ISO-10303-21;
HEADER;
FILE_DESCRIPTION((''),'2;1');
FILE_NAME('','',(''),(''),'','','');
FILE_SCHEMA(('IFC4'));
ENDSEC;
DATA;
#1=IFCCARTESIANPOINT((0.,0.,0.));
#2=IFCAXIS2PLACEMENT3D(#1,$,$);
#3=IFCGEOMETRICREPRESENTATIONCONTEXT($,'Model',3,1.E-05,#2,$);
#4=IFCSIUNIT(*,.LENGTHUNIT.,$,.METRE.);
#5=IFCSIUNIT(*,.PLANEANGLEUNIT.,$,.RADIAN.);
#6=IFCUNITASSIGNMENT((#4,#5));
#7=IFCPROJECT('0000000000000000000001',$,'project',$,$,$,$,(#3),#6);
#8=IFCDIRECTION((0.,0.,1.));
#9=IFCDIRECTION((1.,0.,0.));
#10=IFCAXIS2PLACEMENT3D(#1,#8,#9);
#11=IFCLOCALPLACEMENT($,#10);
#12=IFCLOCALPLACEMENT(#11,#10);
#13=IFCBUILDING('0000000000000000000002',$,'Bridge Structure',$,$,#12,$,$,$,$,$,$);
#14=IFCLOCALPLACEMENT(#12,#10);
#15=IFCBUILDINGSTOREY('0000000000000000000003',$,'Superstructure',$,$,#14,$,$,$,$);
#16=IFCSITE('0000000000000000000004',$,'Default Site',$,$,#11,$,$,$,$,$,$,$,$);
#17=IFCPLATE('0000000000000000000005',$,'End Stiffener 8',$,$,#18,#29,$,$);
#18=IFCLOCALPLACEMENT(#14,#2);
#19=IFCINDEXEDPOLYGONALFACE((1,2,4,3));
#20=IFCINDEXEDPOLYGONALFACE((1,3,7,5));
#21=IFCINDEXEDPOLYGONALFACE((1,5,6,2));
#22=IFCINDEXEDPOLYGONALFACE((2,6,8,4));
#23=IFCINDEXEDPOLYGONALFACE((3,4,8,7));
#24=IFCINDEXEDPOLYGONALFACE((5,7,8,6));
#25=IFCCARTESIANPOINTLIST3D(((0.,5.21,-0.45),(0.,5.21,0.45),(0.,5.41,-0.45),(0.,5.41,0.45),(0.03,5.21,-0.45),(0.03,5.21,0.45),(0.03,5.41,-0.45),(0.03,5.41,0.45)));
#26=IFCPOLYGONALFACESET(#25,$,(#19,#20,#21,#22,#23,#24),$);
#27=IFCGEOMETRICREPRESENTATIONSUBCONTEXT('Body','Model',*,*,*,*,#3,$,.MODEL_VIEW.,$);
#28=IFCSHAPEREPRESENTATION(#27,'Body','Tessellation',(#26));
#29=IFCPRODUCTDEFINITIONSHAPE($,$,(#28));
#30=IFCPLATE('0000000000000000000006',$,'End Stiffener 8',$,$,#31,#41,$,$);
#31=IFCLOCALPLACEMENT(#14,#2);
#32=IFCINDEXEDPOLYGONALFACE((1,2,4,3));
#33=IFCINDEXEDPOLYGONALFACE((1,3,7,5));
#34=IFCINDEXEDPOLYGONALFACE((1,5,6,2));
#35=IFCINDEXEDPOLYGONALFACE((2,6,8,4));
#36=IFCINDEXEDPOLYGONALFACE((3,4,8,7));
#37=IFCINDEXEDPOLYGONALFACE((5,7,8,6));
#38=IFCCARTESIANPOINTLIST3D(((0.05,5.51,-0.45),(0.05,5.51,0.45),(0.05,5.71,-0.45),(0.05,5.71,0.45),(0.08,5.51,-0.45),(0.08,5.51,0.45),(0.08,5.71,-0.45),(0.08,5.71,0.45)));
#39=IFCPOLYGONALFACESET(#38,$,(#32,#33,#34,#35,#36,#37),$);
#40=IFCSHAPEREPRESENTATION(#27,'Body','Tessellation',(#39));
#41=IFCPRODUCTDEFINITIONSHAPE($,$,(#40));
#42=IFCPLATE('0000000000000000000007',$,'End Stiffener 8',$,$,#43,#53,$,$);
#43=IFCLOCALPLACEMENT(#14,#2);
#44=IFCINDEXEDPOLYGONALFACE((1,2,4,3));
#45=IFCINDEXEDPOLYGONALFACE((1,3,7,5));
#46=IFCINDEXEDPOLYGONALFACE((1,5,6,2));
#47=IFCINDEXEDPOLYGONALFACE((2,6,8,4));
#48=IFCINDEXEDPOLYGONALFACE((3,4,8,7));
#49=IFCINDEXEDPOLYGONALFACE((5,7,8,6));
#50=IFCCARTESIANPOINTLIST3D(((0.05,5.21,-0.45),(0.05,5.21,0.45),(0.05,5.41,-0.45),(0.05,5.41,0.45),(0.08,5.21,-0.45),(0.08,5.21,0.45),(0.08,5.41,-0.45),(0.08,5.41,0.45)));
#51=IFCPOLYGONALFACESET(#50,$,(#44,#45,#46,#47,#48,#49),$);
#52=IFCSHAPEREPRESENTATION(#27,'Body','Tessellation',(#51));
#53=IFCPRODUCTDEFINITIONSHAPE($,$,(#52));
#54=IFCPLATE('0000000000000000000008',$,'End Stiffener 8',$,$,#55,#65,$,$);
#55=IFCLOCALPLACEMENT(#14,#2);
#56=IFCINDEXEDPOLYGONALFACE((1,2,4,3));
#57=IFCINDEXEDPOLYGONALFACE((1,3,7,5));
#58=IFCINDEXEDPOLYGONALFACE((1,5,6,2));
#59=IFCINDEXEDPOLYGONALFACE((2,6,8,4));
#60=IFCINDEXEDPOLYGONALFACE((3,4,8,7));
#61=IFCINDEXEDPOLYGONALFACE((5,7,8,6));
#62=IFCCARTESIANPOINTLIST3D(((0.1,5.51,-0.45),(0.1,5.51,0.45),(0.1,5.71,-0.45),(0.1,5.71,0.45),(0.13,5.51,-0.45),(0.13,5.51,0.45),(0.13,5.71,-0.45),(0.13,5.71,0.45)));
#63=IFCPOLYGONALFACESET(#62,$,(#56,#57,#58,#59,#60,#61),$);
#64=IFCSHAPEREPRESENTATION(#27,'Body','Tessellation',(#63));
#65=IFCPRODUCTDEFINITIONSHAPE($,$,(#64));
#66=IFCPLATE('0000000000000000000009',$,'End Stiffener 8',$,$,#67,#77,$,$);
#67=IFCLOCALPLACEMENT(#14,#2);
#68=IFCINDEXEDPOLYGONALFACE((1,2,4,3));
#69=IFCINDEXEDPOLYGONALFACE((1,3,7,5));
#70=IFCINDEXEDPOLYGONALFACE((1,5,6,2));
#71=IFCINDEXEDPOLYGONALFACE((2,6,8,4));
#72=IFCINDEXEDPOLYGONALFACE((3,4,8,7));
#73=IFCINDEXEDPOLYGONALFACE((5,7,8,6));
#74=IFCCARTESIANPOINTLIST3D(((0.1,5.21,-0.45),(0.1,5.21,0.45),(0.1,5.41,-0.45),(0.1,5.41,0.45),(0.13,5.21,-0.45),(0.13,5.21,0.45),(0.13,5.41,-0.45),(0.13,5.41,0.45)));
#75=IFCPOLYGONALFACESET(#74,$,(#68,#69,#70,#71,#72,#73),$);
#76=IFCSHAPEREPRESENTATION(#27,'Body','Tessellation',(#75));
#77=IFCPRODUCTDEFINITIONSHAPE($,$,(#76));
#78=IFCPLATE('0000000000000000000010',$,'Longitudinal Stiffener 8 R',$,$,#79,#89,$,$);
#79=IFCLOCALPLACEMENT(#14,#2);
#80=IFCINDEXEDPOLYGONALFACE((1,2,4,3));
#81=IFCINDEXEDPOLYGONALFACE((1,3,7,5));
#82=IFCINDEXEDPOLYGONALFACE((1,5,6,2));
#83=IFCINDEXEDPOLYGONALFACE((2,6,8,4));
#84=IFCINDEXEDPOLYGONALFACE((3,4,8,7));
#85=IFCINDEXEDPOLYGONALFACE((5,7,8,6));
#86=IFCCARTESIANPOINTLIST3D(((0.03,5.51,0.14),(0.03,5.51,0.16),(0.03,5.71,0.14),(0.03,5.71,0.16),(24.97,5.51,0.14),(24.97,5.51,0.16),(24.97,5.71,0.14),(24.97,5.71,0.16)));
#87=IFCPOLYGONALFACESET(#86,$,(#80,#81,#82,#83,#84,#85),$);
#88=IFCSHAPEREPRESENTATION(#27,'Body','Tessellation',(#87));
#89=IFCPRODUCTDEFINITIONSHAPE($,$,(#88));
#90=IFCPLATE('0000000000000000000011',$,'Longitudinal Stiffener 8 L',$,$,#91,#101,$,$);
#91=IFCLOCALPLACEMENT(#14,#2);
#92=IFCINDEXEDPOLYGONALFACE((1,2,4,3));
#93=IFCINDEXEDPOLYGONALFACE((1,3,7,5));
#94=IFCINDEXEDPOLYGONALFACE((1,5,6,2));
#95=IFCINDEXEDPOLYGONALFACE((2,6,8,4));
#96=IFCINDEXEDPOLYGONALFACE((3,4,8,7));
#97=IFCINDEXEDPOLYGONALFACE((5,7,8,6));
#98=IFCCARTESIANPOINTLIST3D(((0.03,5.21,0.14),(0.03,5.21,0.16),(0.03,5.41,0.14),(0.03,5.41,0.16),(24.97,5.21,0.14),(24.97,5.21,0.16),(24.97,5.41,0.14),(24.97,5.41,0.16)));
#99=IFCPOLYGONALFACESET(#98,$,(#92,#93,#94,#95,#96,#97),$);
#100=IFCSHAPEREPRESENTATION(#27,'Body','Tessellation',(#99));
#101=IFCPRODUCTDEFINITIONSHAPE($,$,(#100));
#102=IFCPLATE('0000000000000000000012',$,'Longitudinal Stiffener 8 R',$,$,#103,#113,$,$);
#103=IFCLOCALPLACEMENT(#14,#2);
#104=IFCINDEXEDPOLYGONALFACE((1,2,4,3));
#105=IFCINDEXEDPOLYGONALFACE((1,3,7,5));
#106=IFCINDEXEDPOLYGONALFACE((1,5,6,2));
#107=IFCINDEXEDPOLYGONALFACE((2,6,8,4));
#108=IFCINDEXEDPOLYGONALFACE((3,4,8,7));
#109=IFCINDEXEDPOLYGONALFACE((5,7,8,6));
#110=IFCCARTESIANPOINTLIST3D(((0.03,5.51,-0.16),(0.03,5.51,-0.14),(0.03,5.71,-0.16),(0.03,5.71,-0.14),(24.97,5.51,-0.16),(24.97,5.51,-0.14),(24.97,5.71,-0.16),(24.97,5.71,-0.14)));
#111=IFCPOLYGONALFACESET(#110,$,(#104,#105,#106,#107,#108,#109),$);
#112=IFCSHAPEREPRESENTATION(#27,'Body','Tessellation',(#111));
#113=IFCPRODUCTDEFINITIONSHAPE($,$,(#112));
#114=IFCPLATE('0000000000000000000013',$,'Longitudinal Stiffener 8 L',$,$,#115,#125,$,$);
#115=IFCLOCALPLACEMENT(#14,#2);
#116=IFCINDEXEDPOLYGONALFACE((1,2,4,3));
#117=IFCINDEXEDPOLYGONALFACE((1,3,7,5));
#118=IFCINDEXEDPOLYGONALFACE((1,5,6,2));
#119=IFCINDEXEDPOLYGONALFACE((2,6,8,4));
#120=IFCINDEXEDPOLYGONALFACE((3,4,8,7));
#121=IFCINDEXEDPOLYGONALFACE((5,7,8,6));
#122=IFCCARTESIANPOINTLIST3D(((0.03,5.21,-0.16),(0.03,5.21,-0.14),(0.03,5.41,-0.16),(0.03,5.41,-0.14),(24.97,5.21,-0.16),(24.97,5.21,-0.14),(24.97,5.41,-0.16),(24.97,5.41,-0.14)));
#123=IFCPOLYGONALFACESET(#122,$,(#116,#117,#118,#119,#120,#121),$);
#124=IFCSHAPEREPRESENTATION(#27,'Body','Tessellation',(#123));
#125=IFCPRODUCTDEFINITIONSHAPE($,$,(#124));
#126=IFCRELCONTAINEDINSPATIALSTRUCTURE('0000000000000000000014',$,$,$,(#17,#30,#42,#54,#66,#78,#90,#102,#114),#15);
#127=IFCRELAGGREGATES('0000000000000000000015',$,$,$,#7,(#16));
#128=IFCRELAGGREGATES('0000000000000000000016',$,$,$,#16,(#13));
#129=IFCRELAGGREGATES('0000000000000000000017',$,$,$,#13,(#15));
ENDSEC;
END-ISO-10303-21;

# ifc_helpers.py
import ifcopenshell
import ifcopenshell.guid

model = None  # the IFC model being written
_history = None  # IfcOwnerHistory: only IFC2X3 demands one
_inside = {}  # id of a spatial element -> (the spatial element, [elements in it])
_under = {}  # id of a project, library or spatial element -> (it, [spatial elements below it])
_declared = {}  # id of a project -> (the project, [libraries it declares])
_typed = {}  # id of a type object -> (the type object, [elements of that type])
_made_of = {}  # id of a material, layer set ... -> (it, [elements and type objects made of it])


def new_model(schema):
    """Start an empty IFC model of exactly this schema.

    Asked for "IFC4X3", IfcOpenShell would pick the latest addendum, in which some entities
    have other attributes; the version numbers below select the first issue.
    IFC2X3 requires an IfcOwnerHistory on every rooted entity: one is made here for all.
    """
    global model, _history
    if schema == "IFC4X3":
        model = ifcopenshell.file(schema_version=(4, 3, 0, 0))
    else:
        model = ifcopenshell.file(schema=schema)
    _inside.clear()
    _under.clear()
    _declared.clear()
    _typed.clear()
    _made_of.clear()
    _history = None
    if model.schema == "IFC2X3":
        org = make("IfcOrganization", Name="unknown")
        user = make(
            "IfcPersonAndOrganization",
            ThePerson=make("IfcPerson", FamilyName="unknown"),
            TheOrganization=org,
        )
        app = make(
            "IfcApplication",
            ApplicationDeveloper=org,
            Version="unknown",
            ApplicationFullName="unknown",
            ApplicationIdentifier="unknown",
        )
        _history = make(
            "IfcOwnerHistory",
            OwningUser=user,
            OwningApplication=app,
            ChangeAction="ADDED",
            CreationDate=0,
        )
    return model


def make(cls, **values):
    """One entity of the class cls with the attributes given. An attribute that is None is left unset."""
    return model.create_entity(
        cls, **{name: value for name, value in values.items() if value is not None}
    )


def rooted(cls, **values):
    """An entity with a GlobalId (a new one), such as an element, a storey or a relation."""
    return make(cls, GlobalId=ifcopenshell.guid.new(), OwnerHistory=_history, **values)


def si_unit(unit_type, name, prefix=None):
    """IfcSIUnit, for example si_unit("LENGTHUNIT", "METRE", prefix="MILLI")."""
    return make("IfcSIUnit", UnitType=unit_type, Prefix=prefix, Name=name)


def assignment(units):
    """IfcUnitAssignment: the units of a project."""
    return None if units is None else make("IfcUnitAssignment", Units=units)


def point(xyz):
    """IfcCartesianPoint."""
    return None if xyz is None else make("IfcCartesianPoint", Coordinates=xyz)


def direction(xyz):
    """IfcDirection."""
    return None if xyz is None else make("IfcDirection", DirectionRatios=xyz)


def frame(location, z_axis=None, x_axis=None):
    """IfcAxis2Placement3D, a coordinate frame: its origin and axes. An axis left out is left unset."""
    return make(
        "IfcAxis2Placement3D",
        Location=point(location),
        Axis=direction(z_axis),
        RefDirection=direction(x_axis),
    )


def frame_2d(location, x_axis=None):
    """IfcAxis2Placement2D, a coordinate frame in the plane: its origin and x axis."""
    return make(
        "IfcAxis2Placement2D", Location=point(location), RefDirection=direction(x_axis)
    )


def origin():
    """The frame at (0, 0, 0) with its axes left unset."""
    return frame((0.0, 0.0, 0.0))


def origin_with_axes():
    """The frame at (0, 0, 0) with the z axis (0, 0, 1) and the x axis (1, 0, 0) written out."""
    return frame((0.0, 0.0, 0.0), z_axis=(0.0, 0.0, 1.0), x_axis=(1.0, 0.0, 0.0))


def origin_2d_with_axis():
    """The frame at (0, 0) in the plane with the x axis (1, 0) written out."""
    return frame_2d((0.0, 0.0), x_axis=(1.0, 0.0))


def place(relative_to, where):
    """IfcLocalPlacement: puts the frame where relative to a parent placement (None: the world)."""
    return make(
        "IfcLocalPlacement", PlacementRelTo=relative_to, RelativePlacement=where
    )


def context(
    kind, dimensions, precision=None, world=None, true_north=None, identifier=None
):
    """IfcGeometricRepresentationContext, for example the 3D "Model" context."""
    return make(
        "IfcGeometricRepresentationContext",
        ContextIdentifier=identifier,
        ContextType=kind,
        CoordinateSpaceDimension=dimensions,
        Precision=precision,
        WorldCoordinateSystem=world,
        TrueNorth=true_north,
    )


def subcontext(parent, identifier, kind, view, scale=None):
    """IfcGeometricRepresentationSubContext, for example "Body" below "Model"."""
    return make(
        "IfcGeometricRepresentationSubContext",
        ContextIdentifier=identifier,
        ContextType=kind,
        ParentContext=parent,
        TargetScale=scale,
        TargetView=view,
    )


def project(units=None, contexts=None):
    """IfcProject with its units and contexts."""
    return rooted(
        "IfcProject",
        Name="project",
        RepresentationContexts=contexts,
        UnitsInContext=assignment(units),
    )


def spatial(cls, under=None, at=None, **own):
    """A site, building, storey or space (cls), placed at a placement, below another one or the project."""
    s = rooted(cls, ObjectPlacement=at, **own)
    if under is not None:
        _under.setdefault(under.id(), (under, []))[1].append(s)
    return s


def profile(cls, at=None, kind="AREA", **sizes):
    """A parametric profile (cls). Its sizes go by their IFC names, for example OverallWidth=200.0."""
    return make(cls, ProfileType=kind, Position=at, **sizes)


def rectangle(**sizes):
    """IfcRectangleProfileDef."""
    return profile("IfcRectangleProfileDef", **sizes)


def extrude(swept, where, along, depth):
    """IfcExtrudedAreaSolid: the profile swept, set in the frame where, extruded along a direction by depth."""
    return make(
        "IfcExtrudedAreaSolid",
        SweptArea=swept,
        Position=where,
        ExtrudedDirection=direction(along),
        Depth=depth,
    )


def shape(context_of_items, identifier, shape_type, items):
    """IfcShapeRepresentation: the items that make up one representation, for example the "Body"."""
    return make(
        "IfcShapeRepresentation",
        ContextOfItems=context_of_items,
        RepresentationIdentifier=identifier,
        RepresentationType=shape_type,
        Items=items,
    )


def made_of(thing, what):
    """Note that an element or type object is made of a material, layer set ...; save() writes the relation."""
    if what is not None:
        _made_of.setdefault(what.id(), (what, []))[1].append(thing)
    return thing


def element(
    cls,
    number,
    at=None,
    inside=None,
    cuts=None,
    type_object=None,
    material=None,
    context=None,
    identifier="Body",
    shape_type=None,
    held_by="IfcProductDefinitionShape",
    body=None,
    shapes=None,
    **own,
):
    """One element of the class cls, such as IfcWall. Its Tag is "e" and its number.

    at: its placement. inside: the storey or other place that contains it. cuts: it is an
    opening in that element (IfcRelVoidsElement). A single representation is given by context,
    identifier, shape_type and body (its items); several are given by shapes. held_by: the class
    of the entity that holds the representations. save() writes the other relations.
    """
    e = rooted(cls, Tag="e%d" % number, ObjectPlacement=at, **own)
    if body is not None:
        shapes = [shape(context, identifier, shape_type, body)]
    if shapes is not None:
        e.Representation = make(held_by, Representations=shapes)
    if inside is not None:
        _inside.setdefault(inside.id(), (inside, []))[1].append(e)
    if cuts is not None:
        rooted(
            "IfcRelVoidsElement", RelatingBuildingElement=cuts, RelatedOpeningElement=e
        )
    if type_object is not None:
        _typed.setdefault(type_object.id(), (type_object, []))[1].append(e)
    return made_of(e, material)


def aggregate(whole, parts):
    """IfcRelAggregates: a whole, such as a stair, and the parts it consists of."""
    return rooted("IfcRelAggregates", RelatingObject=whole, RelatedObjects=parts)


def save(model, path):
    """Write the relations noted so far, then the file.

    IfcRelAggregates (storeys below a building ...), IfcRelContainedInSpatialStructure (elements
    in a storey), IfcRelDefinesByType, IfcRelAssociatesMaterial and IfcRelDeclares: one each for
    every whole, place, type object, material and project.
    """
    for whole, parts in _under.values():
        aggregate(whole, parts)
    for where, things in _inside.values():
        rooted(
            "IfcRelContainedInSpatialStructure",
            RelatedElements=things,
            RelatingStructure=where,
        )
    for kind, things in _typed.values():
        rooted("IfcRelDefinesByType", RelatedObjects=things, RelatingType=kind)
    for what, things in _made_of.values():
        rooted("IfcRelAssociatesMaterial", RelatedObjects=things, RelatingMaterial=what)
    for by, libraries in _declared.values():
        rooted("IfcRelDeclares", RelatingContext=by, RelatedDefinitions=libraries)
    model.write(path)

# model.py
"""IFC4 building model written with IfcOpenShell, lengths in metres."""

from ifc_helpers import new_model, si_unit, frame, origin, origin_with_axes, origin_2d_with_axis, place, context, subcontext, project, spatial, rectangle, extrude, element, save


model = new_model("IFC4")

# Units and contexts
model_context = context("Model", 3, precision=1e-05, world=origin())
body_context = subcontext(model_context, "Body", "Model", "MODEL_VIEW")
ifc_project = project(units=[si_unit("LENGTHUNIT", "METRE"), si_unit("PLANEANGLEUNIT", "RADIAN")], contexts=[model_context])

# Site, building, storey
site_placement = place(None, origin_with_axes())
site = spatial("IfcSite", under=ifc_project, at=site_placement, Name="Default Site")
building_placement = place(site_placement, origin_with_axes())
building = spatial("IfcBuilding", under=site, at=building_placement, Name="Bridge Structure")
storey_placement = place(building_placement, origin_with_axes())
storey = spatial("IfcBuildingStorey", under=building, at=storey_placement, Name="Superstructure")

# Plates
for number, where, z_axis, x_axis, name in (
    (1, (0.015, 5.31, -0.45), (0.0, 0.0, 1.0), (1.0, 0.0, 0.0), "End Stiffener 8"),
    (2, (0.065, 5.61, -0.45), (0.0, 0.0, 1.0), (1.0, 0.0, 0.0), "End Stiffener 8"),
    (3, (0.065, 5.31, -0.45), (0.0, 0.0, 1.0), (1.0, 0.0, 0.0), "End Stiffener 8"),
    (4, (0.115, 5.61, -0.45), (0.0, 0.0, 1.0), (1.0, 0.0, 0.0), "End Stiffener 8"),
    (5, (0.115, 5.31, -0.45), (0.0, 0.0, 1.0), (1.0, 0.0, 0.0), "End Stiffener 8"),
):
    element("IfcPlate", number, at=place(storey_placement, frame(where, z_axis=z_axis, x_axis=x_axis)), inside=storey, Name=name, context=body_context, shape_type="SweptSolid", body=[
        extrude(rectangle(XDim=0.03, YDim=0.2, at=origin_2d_with_axis()), origin_with_axes(), (0.0, 0.0, 1.0), 0.9),
    ])
for number, where, z_axis, x_axis, name in (
    (6, (0.03, 5.61, 0.15), (1.0, 0.0, 0.0), (0.0, 1.0, 0.0), "Longitudinal Stiffener 8 R"),
    (7, (0.03, 5.31, 0.15), (1.0, 0.0, 0.0), (0.0, 1.0, 0.0), "Longitudinal Stiffener 8 L"),
    (8, (0.03, 5.61, -0.15), (1.0, 0.0, 0.0), (0.0, 1.0, 0.0), "Longitudinal Stiffener 8 R"),
    (9, (0.03, 5.31, -0.15), (1.0, 0.0, 0.0), (0.0, 1.0, 0.0), "Longitudinal Stiffener 8 L"),
):
    element("IfcPlate", number, at=place(storey_placement, frame(where, z_axis=z_axis, x_axis=x_axis)), inside=storey, Name=name, context=body_context, shape_type="SweptSolid", body=[
        extrude(rectangle(XDim=0.2, YDim=0.02, at=origin_2d_with_axis()), origin_with_axes(), (0.0, 0.0, 1.0), 24.94),
    ])

save(model, "model.ifc")
